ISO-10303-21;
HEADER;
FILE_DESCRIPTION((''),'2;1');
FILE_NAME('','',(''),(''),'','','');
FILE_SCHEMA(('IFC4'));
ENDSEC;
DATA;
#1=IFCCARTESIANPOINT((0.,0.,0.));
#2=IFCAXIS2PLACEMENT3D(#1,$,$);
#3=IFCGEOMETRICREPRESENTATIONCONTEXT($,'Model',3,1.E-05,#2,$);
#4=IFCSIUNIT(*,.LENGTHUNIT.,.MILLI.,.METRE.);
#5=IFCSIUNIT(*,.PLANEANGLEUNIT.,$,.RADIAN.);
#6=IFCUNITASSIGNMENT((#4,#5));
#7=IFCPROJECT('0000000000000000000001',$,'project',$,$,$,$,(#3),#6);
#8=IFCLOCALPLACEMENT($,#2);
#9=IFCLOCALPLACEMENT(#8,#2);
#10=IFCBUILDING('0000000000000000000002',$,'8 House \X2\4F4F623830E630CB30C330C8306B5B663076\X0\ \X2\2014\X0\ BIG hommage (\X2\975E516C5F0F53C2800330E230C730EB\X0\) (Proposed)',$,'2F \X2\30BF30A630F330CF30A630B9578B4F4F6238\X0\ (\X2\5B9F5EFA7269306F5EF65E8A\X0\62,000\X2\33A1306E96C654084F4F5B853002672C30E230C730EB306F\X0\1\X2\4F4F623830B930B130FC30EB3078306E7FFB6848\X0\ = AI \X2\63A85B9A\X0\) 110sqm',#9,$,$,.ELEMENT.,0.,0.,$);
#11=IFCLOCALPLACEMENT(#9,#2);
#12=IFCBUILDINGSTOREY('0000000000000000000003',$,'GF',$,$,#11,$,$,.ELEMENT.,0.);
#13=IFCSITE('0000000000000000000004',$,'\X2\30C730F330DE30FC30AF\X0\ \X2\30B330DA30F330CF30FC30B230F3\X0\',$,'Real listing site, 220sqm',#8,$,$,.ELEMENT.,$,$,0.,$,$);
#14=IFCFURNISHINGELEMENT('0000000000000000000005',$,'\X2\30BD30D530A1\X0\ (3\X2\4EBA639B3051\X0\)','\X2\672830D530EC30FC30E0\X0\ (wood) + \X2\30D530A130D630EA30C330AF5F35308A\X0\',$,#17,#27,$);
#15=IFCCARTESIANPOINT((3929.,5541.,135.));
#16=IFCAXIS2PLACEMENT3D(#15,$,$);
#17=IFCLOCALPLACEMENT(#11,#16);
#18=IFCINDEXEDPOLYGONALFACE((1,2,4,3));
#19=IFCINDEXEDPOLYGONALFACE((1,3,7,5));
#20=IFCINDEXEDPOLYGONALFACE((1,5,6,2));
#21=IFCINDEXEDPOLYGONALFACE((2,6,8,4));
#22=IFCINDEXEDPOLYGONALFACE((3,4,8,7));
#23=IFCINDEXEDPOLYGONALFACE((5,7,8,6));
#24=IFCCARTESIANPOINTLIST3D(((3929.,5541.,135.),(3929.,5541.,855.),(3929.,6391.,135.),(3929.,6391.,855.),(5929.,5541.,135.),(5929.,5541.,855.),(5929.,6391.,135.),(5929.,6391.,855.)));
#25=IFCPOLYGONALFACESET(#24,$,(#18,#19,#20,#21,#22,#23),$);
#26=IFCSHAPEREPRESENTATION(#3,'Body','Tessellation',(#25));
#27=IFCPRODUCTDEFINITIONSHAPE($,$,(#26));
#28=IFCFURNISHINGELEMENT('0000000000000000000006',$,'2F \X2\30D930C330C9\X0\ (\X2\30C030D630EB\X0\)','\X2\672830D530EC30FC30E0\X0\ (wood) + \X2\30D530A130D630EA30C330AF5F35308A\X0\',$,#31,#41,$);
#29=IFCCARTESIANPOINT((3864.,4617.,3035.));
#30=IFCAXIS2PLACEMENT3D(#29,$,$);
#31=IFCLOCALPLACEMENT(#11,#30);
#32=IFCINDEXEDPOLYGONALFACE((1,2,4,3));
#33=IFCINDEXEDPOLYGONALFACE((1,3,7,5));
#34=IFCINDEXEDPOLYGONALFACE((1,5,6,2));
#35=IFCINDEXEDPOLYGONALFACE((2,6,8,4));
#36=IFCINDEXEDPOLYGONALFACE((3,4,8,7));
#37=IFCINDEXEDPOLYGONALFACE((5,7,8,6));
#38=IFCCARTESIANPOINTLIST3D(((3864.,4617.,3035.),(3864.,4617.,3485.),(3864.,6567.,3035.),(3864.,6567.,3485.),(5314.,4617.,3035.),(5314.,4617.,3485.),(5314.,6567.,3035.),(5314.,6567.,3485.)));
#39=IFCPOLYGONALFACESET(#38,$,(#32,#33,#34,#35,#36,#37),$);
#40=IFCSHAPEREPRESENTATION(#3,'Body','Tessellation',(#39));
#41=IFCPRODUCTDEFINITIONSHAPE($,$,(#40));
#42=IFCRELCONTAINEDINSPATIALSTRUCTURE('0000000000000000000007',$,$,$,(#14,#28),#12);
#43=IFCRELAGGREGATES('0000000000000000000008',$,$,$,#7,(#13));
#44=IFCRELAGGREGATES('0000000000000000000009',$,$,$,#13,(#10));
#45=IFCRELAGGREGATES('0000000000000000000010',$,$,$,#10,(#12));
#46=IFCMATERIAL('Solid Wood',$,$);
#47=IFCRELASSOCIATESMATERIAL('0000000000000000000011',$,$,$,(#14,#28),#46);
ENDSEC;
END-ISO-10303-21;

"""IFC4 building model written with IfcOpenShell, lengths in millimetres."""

from ifc_helpers import new_model, si_unit, frame, frame_2d, origin, place, context, project, spatial, rectangle, extrude, material, element, save


model = new_model("IFC4")

# Units and contexts
model_context = context("Model", 3, precision=1e-05, world=origin())
ifc_project = project(units=[si_unit("LENGTHUNIT", "METRE", prefix="MILLI"), si_unit("PLANEANGLEUNIT", "RADIAN")], contexts=[model_context])

# Site, building, storey
site_placement = place(None, origin())
site = spatial("IfcSite", under=ifc_project, at=site_placement, Name="デンマーク コペンハーゲン", ObjectType="Real listing site, 220sqm", CompositionType="ELEMENT", RefElevation=0.0)
building_placement = place(site_placement, origin())
building = spatial("IfcBuilding", under=site, at=building_placement, Name="8 House 住戸ユニットに学ぶ — BIG hommage (非公式参考モデル) (Proposed)", ObjectType="2F タウンハウス型住戸 (実建物は延床62,000㎡の集合住宅。本モデルは1住戸スケールへの翻案 = AI 推定) 110sqm", CompositionType="ELEMENT", ElevationOfRefHeight=0.0, ElevationOfTerrain=0.0)
storey_placement = place(building_placement, origin())
storey = spatial("IfcBuildingStorey", under=building, at=storey_placement, Name="GF", CompositionType="ELEMENT", Elevation=0.0)

# Shared definitions
ifc_material_1 = material(Name="Solid Wood")

# Furnishing elements
furnishing_1_placement = place(storey_placement, frame((3929.0, 5541.0, 135.0)))
element("IfcFurnishingElement", 1, at=furnishing_1_placement, inside=storey, material=ifc_material_1, Name="ソファ (3人掛け)", Description="木フレーム (wood) + ファブリック張り", context=model_context, shape_type="SweptSolid", body=[
    extrude(rectangle(XDim=2000.0, YDim=850.0, at=frame_2d((1000.0, 425.0))), frame((3929.0, 5541.0, 135.0)), (0.0, 0.0, 1.0), 720.0),
])
furnishing_2_placement = place(storey_placement, frame((3864.0, 4617.0, 3035.0)))
element("IfcFurnishingElement", 2, at=furnishing_2_placement, inside=storey, material=ifc_material_1, Name="2F ベッド (ダブル)", Description="木フレーム (wood) + ファブリック張り", context=model_context, shape_type="SweptSolid", body=[
    extrude(rectangle(XDim=1450.0, YDim=1950.0, at=frame_2d((725.0, 975.0))), frame((3864.0, 4617.0, 3035.0)), (0.0, 0.0, 1.0), 450.0),
])

save(model, "model.ifc")
